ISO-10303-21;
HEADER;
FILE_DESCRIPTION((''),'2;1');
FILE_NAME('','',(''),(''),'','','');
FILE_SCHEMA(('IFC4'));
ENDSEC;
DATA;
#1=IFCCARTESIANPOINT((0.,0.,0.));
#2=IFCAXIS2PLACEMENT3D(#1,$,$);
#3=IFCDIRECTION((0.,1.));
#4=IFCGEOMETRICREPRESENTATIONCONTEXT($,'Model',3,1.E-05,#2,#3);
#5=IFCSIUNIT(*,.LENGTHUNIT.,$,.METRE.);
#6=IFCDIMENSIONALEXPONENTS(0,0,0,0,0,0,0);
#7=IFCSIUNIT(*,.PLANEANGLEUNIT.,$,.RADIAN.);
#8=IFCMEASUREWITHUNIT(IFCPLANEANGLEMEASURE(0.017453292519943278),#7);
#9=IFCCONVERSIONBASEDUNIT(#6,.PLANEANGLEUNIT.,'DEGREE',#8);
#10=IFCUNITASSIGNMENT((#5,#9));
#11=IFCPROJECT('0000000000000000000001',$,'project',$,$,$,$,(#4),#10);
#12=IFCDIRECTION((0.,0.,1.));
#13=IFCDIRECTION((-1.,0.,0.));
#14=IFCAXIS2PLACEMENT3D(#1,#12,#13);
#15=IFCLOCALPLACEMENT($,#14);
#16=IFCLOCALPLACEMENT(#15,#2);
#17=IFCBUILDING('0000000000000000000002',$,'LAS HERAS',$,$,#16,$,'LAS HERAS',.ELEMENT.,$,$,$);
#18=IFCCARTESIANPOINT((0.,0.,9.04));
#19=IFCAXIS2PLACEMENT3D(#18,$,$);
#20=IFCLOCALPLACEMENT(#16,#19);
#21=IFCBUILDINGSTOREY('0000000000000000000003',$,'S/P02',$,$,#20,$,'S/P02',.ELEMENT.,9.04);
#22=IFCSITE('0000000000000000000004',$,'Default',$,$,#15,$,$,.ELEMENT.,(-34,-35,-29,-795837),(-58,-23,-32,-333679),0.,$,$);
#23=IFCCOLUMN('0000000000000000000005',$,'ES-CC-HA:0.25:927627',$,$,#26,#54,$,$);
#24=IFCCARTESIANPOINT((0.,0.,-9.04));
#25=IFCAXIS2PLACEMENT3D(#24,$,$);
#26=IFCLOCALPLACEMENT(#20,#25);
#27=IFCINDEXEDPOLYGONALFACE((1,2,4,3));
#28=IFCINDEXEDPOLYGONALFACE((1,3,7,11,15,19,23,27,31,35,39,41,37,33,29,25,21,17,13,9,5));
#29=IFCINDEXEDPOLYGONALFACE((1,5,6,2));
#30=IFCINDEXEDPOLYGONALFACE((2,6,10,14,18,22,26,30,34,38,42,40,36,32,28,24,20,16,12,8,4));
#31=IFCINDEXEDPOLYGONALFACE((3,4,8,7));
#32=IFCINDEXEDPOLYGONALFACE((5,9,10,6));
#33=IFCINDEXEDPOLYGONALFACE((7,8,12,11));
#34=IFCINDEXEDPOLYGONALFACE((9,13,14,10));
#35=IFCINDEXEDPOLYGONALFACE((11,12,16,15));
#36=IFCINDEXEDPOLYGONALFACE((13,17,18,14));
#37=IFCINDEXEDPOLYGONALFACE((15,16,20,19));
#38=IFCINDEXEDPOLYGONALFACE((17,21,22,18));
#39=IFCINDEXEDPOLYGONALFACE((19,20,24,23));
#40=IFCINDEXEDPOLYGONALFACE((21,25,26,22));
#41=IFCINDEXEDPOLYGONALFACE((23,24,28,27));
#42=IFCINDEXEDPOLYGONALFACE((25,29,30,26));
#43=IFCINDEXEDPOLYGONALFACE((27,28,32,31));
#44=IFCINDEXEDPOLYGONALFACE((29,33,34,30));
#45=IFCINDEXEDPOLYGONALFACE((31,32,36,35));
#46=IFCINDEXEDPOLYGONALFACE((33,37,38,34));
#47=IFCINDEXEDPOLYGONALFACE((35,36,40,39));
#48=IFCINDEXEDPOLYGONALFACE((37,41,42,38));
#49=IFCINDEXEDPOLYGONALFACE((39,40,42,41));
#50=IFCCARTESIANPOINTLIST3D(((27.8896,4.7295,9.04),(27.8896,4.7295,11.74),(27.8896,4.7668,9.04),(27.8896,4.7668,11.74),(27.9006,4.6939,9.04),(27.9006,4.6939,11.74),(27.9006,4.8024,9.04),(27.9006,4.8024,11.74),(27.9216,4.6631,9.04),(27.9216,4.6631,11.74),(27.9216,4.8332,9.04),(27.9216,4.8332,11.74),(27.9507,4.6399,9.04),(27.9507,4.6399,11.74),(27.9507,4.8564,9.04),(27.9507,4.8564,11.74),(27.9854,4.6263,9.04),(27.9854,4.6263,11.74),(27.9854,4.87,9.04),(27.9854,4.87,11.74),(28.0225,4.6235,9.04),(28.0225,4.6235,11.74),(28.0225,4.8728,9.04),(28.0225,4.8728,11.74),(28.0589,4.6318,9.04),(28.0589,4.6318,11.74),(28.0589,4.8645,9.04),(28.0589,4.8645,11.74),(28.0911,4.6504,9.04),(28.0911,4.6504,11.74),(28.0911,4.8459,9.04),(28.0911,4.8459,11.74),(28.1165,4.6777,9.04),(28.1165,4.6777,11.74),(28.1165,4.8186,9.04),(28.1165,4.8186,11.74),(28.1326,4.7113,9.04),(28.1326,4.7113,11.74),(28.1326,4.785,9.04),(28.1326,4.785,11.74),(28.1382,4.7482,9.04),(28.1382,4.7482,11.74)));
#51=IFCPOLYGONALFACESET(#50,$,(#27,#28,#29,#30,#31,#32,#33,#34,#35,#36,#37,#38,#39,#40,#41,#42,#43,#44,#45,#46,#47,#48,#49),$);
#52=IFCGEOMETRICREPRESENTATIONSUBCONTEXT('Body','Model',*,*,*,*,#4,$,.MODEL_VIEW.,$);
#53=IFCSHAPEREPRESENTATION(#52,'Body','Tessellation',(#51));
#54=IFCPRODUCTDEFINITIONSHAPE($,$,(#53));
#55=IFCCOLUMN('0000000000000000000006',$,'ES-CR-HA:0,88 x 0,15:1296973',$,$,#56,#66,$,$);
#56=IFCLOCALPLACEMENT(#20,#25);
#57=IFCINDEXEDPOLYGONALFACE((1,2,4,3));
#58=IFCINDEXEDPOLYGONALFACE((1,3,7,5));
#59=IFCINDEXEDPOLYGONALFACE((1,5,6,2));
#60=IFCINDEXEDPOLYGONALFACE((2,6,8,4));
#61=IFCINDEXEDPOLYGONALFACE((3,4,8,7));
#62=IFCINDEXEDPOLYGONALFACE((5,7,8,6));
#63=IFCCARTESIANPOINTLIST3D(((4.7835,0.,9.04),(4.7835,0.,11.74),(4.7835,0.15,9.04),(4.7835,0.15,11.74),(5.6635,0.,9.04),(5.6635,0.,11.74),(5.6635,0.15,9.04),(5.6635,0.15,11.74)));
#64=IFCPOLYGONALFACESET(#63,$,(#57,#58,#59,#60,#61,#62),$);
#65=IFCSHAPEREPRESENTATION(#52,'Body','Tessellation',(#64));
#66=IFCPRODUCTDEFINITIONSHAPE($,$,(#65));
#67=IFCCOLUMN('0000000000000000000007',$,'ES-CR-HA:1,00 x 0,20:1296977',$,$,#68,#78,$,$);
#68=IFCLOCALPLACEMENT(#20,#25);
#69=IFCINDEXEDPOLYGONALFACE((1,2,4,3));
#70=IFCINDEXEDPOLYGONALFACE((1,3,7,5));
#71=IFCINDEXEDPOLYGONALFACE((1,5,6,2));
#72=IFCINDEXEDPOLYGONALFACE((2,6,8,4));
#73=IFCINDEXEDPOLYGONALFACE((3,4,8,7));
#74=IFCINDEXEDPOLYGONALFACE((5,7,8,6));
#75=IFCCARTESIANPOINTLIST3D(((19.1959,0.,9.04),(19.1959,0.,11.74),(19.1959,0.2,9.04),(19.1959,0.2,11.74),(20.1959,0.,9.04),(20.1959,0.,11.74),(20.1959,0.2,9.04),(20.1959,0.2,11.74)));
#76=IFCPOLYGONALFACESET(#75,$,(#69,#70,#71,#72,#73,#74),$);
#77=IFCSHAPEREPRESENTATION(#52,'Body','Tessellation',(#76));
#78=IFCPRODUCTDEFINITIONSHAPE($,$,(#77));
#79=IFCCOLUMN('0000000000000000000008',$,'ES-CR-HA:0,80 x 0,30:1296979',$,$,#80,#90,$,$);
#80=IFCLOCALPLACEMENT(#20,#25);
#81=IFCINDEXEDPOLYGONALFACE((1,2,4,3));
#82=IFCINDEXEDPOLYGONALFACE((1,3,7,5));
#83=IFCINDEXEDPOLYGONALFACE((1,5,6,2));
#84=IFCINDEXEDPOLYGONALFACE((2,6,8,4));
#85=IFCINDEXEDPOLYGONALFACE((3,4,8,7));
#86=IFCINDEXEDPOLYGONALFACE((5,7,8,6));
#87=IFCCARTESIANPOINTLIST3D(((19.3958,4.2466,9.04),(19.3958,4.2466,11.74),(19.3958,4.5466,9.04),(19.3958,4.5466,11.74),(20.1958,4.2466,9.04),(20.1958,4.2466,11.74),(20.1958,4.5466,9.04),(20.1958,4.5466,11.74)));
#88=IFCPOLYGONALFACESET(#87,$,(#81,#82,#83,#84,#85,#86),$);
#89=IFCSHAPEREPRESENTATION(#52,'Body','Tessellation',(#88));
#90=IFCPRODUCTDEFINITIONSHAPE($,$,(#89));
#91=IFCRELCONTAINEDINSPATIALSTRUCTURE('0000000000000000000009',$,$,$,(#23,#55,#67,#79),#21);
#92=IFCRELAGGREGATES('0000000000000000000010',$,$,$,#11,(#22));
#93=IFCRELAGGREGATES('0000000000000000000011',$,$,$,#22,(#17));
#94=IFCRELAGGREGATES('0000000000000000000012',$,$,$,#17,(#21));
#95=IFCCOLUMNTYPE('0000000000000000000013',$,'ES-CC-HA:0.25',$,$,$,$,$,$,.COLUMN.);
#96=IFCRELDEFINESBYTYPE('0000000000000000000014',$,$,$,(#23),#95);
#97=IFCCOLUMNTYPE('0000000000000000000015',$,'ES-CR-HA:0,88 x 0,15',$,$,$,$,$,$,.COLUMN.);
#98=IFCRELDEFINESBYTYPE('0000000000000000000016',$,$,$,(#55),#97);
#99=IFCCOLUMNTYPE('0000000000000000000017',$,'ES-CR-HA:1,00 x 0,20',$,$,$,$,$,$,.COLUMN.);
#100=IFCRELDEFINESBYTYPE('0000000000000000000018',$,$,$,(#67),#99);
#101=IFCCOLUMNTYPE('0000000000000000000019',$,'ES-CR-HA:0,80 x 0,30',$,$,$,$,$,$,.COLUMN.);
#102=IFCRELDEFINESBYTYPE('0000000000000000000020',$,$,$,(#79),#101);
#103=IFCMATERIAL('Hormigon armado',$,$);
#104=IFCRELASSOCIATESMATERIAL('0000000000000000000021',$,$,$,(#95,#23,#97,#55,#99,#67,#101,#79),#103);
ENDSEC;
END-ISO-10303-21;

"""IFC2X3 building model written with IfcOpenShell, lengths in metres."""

from ifc_helpers import new_model, entity, si_unit, converted_unit, direction, frame, frame_2d, origin, origin_2d_with_axis, place, context, subcontext, project, spatial, rectangle, circle, extrude, source, transform, mapped, material, type_object, type_shapes, element, save


model = new_model("IFC2X3")

# Units and contexts
model_context = context("Model", 3, precision=1e-05, world=origin(), true_north=direction((0.0, 1.0)))
body_context = subcontext(model_context, "Body", "Model", "MODEL_VIEW")
ifc_project = project(units=[si_unit("LENGTHUNIT", "METRE"), converted_unit("PLANEANGLEUNIT", "DEGREE", entity("IfcPlaneAngleMeasure", 0.017453292519943278), si_unit("PLANEANGLEUNIT", "RADIAN"), dimensions=[0, 0, 0, 0, 0, 0, 0])], contexts=[model_context])

# Site, building, storey
site_placement = place(None, frame((0.0, 0.0, 0.0), z_axis=(0.0, 0.0, 1.0), x_axis=(-1.0, 0.0, 0.0)))
site = spatial("IfcSite", under=ifc_project, at=site_placement, Name="Default", CompositionType="ELEMENT", RefLatitude=(-34, -35, -29, -795837), RefLongitude=(-58, -23, -32, -333679), RefElevation=0.0)
building_placement = place(site_placement, origin())
building = spatial("IfcBuilding", under=site, at=building_placement, Name="LAS HERAS", LongName="LAS HERAS", CompositionType="ELEMENT")
storey_placement = place(building_placement, frame((0.0, 0.0, 9.04)))
storey = spatial("IfcBuildingStorey", under=building, at=storey_placement, Name="S/P02", LongName="S/P02", CompositionType="ELEMENT", Elevation=9.04)

# Columns
ifc_material = material(Name="Hormigon armado")
column_type_1 = type_object("IfcColumnType", Name="ES-CC-HA:0.25", PredefinedType="COLUMN", material=ifc_material)
shared_shape_1 = source(origin(), body_context, "Body", "SweptSolid", [
    extrude(circle(Radius=0.125, at=origin_2d_with_axis()), frame((28.0132, 4.7482, 9.04)), (0.0, 0.0, 1.0), 2.7),
])
type_shapes(column_type_1, [shared_shape_1])
column_1_placement = place(storey_placement, frame((0.0, 0.0, -9.04)))
element("IfcColumn", 1, at=column_1_placement, inside=storey, type_object=column_type_1, material=ifc_material, Name="ES-CC-HA:0.25:927627", context=body_context, shape_type="MappedRepresentation", body=[
    mapped(shared_shape_1, transform((0.0, 0.0, 0.0), scale=1.0)),
])
column_type_2 = type_object("IfcColumnType", Name="ES-CR-HA:0,88 x 0,15", PredefinedType="COLUMN", material=ifc_material)
shared_shape_2 = source(origin(), body_context, "Body", "SweptSolid", [
    extrude(rectangle(XDim=2.7, YDim=0.15, at=frame_2d((0.0, 0.0), x_axis=(1.0, 0.0))), frame((4.7835, 0.075, 10.39), z_axis=(1.0, 0.0, 0.0), x_axis=(0.0, 0.0, 1.0)), (0.0, 0.0, 1.0), 0.88),
])
type_shapes(column_type_2, [shared_shape_2])
column_2_placement = place(storey_placement, frame((0.0, 0.0, -9.04)))
element("IfcColumn", 2, at=column_2_placement, inside=storey, type_object=column_type_2, material=ifc_material, Name="ES-CR-HA:0,88 x 0,15:1296973", context=body_context, shape_type="MappedRepresentation", body=[
    mapped(shared_shape_2, transform((0.0, 0.0, 0.0), scale=1.0)),
])
column_type_3 = type_object("IfcColumnType", Name="ES-CR-HA:1,00 x 0,20", PredefinedType="COLUMN", material=ifc_material)
shared_shape_3 = source(origin(), body_context, "Body", "SweptSolid", [
    extrude(rectangle(XDim=2.7, YDim=0.2, at=frame_2d((0.0, 0.0), x_axis=(1.0, 0.0))), frame((19.1959, 0.1, 10.39), z_axis=(1.0, 0.0, 0.0), x_axis=(0.0, 0.0, 1.0)), (0.0, 0.0, 1.0), 1.0),
])
type_shapes(column_type_3, [shared_shape_3])
column_3_placement = place(storey_placement, frame((0.0, 0.0, -9.04)))
element("IfcColumn", 3, at=column_3_placement, inside=storey, type_object=column_type_3, material=ifc_material, Name="ES-CR-HA:1,00 x 0,20:1296977", context=body_context, shape_type="MappedRepresentation", body=[
    mapped(shared_shape_3, transform((0.0, 0.0, 0.0), scale=1.0)),
])
column_type_4 = type_object("IfcColumnType", Name="ES-CR-HA:0,80 x 0,30", PredefinedType="COLUMN", material=ifc_material)
shared_shape_4 = source(origin(), body_context, "Body", "SweptSolid", [
    extrude(rectangle(XDim=2.7, YDim=0.3, at=origin_2d_with_axis()), frame((19.3958, 4.3966, 10.39), z_axis=(1.0, 0.0, 0.0), x_axis=(0.0, 0.0, 1.0)), (0.0, 0.0, 1.0), 0.8),
])
type_shapes(column_type_4, [shared_shape_4])
column_4_placement = place(storey_placement, frame((0.0, 0.0, -9.04)))
element("IfcColumn", 4, at=column_4_placement, inside=storey, type_object=column_type_4, material=ifc_material, Name="ES-CR-HA:0,80 x 0,30:1296979", context=body_context, shape_type="MappedRepresentation", body=[
    mapped(shared_shape_4, transform((0.0, 0.0, 0.0), scale=1.0)),
])

save(model, "model.ifc")
